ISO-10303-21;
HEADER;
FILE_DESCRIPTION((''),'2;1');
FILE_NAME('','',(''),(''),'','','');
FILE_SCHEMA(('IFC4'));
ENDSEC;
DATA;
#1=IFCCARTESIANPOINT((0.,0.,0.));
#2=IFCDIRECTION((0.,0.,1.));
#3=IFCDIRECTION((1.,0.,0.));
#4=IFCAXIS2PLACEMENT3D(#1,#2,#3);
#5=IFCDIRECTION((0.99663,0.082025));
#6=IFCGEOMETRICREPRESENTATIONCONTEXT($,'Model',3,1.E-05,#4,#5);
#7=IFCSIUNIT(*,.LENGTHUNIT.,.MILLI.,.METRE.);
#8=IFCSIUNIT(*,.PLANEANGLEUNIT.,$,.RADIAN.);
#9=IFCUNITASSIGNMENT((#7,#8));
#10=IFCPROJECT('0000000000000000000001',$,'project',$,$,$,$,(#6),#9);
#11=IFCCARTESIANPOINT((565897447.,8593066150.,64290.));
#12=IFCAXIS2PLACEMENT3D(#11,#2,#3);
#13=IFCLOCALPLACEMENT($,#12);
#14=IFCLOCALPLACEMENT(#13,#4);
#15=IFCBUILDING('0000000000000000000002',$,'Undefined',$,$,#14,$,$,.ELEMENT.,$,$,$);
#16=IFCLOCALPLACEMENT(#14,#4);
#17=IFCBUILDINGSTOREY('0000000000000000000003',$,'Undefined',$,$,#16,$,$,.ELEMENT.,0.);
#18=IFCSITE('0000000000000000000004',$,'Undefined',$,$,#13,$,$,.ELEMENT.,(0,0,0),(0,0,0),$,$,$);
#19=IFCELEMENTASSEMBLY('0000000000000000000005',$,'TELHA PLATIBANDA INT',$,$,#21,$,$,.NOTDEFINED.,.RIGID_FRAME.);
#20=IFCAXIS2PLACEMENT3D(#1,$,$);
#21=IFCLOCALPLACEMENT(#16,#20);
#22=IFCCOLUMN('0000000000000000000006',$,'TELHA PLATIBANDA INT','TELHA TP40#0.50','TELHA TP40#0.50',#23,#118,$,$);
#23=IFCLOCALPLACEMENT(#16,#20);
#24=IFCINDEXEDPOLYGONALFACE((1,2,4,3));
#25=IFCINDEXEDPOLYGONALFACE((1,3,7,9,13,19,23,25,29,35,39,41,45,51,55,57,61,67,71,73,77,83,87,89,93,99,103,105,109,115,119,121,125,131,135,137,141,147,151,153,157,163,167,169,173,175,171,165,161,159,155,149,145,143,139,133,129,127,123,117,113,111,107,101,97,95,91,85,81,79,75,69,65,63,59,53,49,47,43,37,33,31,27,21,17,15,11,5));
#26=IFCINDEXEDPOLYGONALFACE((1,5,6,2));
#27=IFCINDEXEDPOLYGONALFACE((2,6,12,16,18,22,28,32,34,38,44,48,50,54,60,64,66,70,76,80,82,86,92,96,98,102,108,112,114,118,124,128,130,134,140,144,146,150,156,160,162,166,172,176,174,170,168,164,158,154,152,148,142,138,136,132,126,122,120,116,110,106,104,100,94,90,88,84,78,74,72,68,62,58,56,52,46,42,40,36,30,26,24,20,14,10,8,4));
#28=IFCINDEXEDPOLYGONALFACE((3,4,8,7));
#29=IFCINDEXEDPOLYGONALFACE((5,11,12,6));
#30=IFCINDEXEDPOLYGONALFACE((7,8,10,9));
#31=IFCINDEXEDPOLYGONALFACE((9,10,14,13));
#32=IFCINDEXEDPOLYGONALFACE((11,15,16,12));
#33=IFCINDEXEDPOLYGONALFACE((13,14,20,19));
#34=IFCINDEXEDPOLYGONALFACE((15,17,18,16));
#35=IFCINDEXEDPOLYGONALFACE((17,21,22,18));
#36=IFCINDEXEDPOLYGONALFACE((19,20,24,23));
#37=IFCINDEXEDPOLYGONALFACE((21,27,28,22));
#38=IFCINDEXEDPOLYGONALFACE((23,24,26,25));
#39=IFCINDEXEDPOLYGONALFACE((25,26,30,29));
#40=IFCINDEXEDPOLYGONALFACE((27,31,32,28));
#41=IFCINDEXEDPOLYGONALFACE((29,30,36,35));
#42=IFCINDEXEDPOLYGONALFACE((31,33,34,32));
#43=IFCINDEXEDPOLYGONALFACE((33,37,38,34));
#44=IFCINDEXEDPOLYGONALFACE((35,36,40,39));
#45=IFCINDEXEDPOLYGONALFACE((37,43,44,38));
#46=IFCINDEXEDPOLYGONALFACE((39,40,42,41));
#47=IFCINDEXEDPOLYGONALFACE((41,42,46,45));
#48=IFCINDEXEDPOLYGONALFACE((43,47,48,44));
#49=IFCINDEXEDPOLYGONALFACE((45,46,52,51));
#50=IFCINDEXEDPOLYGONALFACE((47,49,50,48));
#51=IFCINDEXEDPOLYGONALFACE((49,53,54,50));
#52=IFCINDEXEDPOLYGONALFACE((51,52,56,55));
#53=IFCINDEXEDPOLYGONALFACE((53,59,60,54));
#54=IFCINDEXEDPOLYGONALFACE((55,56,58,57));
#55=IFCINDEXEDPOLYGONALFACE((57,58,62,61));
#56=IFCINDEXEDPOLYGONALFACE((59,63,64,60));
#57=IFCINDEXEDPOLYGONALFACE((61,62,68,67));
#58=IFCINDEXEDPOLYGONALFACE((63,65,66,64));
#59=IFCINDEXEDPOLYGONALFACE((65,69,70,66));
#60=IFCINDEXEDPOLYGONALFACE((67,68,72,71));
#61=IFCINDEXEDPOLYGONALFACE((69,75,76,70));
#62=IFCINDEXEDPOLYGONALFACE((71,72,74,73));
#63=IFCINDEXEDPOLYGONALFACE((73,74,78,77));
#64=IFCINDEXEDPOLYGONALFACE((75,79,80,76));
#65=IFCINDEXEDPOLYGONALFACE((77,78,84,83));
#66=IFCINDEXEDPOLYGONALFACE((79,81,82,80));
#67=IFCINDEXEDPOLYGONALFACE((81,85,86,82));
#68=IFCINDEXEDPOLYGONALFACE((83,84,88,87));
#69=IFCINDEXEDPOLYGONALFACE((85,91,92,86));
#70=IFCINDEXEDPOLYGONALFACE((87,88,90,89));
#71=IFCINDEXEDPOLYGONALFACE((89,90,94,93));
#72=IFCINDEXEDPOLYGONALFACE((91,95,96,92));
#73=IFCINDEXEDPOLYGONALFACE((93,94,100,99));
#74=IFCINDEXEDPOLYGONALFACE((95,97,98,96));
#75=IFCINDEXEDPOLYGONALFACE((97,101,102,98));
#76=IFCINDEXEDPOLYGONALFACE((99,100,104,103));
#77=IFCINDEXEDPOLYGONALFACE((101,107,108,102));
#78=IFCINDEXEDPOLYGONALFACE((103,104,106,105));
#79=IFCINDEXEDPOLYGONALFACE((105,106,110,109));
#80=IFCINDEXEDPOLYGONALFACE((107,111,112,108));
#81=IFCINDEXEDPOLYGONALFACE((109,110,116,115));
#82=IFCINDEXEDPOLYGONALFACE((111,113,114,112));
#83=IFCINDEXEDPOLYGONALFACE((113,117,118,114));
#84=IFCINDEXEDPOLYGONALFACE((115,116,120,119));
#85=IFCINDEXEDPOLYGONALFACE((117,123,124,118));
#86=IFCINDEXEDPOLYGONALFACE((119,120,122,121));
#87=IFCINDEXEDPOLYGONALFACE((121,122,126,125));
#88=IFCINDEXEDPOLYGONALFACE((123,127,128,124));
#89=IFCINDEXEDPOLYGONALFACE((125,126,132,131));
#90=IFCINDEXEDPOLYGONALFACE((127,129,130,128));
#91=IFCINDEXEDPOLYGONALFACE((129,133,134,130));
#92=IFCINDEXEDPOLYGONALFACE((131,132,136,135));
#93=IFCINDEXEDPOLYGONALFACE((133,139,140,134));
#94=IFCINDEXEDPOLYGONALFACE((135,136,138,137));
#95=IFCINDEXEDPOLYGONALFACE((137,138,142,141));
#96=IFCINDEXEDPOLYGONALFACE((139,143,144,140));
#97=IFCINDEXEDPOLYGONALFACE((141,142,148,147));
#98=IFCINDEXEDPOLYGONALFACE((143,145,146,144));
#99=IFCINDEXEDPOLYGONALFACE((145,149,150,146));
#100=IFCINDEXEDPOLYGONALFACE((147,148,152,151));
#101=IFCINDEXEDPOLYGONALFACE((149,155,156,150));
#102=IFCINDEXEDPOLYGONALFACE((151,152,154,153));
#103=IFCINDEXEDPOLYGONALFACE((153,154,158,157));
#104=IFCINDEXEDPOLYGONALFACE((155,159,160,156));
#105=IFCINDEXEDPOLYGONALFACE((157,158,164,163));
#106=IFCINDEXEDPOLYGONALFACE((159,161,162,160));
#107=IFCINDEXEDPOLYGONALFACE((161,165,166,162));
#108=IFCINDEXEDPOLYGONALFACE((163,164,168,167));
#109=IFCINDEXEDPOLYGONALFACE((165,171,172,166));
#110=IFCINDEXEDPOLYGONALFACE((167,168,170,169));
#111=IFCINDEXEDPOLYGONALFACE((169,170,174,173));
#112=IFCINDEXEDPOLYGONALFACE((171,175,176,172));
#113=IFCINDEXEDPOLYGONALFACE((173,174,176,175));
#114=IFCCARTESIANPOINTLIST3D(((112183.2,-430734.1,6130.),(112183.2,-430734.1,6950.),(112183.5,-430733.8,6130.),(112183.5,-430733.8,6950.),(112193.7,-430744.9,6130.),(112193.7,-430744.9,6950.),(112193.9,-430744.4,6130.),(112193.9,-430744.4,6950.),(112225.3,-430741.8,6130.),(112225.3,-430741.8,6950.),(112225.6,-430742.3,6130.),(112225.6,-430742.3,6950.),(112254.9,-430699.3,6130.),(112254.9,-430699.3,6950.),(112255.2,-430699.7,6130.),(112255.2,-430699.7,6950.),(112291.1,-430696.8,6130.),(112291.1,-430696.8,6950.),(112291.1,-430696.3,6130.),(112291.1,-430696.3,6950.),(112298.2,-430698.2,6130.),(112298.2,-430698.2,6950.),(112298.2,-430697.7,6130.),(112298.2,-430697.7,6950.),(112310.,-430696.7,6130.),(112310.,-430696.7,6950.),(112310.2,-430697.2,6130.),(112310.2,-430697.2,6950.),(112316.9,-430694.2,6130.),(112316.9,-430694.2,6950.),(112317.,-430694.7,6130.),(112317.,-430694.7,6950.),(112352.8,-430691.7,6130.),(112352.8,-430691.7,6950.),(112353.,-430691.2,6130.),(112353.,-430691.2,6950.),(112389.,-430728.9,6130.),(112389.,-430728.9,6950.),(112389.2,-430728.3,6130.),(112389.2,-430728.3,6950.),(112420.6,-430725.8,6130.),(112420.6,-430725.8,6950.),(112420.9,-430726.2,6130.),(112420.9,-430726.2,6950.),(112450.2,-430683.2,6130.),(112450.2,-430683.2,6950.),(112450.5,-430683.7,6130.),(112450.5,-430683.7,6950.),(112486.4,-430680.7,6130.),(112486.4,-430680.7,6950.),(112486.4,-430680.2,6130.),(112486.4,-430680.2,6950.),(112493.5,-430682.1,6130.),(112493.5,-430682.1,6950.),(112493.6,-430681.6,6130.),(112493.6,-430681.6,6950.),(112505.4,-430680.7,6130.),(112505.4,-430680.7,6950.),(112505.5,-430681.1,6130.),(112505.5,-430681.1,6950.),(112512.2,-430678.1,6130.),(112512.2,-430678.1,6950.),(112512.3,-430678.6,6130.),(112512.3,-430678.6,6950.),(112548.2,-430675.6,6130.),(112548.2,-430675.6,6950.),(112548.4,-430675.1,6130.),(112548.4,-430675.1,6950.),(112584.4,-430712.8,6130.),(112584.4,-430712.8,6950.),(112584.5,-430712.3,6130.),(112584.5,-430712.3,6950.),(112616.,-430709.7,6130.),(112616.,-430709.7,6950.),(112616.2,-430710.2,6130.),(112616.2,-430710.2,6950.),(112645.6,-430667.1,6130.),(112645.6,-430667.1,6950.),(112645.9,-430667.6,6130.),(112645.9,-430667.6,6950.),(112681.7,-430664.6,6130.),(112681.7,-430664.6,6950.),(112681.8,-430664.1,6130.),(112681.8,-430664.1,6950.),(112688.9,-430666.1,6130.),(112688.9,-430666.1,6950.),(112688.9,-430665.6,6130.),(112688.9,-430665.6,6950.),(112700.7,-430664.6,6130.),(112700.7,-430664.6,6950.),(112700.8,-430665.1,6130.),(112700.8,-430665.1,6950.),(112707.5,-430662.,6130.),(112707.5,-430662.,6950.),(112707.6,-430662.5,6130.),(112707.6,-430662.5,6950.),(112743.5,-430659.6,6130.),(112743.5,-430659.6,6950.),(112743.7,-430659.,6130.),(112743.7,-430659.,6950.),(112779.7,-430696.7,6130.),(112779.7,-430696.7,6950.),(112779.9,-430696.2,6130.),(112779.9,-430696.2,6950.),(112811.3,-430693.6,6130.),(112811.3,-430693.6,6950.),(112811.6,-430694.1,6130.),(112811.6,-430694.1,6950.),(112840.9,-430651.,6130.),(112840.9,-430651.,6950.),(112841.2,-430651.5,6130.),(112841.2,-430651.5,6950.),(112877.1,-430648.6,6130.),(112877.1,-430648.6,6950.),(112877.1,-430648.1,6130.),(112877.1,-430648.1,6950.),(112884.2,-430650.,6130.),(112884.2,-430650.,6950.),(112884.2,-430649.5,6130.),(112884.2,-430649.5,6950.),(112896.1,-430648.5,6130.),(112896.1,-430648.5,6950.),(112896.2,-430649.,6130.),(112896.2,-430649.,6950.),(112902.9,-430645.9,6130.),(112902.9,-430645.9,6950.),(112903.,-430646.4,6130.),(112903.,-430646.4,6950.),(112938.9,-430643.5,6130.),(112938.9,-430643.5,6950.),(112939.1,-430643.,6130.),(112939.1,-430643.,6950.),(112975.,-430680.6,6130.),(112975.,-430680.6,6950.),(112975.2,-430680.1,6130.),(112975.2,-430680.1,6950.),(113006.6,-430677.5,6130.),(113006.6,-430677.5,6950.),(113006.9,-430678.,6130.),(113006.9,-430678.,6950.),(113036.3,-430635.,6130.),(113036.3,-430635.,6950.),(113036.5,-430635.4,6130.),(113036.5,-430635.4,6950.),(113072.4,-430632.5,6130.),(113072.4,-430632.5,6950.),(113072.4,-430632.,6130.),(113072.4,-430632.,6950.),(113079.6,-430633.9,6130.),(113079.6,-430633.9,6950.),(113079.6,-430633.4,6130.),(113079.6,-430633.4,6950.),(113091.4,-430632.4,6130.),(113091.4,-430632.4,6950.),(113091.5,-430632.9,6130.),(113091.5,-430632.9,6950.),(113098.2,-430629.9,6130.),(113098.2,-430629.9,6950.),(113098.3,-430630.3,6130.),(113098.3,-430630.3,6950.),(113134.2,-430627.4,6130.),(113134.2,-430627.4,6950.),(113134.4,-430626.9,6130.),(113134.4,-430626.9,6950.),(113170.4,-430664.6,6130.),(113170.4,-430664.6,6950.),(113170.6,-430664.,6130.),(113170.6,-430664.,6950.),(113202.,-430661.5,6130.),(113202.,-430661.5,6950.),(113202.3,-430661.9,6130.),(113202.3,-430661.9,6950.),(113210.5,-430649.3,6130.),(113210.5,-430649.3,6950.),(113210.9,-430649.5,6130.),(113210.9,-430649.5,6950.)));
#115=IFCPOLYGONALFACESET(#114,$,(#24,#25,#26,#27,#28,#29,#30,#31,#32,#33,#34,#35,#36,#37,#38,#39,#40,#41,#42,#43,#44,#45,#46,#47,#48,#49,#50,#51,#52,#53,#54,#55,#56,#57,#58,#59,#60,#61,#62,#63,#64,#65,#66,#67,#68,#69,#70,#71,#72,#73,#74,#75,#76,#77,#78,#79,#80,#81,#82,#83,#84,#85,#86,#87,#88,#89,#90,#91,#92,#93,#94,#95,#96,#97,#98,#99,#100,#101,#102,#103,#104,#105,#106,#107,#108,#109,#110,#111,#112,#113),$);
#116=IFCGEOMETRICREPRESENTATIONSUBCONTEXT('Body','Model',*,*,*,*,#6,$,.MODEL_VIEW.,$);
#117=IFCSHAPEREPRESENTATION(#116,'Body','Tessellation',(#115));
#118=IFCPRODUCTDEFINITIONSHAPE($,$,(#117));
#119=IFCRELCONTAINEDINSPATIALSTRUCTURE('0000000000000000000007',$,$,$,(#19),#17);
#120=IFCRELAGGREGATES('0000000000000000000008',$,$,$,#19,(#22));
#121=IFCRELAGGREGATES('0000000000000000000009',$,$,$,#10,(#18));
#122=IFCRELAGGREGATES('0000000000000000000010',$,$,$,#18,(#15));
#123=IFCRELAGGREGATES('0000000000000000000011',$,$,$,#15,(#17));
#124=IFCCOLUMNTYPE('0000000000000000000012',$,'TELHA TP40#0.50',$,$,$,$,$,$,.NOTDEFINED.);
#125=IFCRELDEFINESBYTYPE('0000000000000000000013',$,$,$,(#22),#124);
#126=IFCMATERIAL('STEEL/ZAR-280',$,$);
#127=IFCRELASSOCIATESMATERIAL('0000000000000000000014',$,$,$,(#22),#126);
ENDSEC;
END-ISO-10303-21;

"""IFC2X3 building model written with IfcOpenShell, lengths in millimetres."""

from ifc_helpers import new_model, si_unit, direction, frame, origin_with_axes, place, context, subcontext, project, spatial, polyline, outline, extrude, material, type_object, element, aggregate, save


model = new_model("IFC2X3")

# Units and contexts
model_context = context("Model", 3, precision=1e-05, world=origin_with_axes(), true_north=direction((0.99663, 0.082025)))
body_context = subcontext(model_context, "Body", "Model", "MODEL_VIEW")
ifc_project = project(units=[si_unit("LENGTHUNIT", "METRE", prefix="MILLI"), si_unit("PLANEANGLEUNIT", "RADIAN")], contexts=[model_context])

# Site, building, storey
site_placement = place(None, frame((565897447.0, 8593066150.0, 64290.0), z_axis=(0.0, 0.0, 1.0), x_axis=(1.0, 0.0, 0.0)))
site = spatial("IfcSite", under=ifc_project, at=site_placement, Name="Undefined", CompositionType="ELEMENT", RefLatitude=(0, 0, 0), RefLongitude=(0, 0, 0))
building_placement = place(site_placement, origin_with_axes())
building = spatial("IfcBuilding", under=site, at=building_placement, Name="Undefined", CompositionType="ELEMENT")
storey_placement = place(building_placement, origin_with_axes())
storey = spatial("IfcBuildingStorey", under=building, at=storey_placement, Name="Undefined", CompositionType="ELEMENT", Elevation=0.0)

# Element assembly, column
assembly_1_placement = place(storey_placement, origin_with_axes())
assembly_1 = element("IfcElementAssembly", 1, at=assembly_1_placement, inside=storey, Name="TELHA PLATIBANDA INT", AssemblyPlace="NOTDEFINED", PredefinedType="RIGID_FRAME")
ifc_material_1 = material(Name="STEEL/ZAR-280")
column_type = type_object("IfcColumnType", Name="TELHA TP40#0.50", PredefinedType="NOTDEFINED")
column_1_placement = place(assembly_1_placement, frame((112696.5, -430683.2, 6130.0), z_axis=(0.0, 0.0, 1.0), x_axis=(0.082025, -0.99663, 0.0)))
column_1 = element("IfcColumn", 2, at=column_1_placement, type_object=column_type, material=ifc_material_1, Name="TELHA PLATIBANDA INT", Description="TELHA TP40#0.50", ObjectType="TELHA TP40#0.50", context=body_context, shape_type="SweptSolid", body=[
    extrude(outline(polyline([(440.8, -19.8), (473.8, 20.2), (505.8, 20.2), (515.4, 8.6), (515.0, 8.3), (505.6, 19.8), (474.0, 19.8), (441.0, -20.2), (404.7, -20.2), (397.7, -18.2), (385.9, -18.2), (378.9, -20.2), (342.6, -20.2), (309.6, 19.8), (278.0, 19.8), (245.0, -20.2), (208.7, -20.2), (201.7, -18.2), (189.9, -18.2), (182.9, -20.2), (146.6, -20.2), (113.6, 19.8), (82.0, 19.8), (49.0, -20.2), (12.7, -20.2), (5.7, -18.2), (-6.1, -18.2), (-13.1, -20.2), (-49.4, -20.2), (-82.4, 19.8), (-114.0, 19.8), (-147.0, -20.2), (-183.3, -20.2), (-190.3, -18.2), (-202.1, -18.2), (-209.1, -20.2), (-245.4, -20.2), (-278.4, 19.8), (-310.0, 19.8), (-343.0, -20.2), (-379.3, -20.2), (-386.3, -18.2), (-398.1, -18.2), (-405.1, -20.2), (-441.4, -20.2), (-474.4, 19.8), (-506.0, 19.8), (-515.4, 8.3), (-515.8, 8.6), (-506.2, 20.2), (-474.2, 20.2), (-441.2, -19.8), (-405.2, -19.8), (-398.2, -17.8), (-386.2, -17.8), (-379.2, -19.8), (-343.2, -19.8), (-310.2, 20.2), (-278.2, 20.2), (-245.2, -19.8), (-209.2, -19.8), (-202.2, -17.8), (-190.2, -17.8), (-183.2, -19.8), (-147.2, -19.8), (-114.2, 20.2), (-82.2, 20.2), (-49.2, -19.8), (-13.2, -19.8), (-6.2, -17.8), (5.8, -17.8), (12.8, -19.8), (48.8, -19.8), (81.8, 20.2), (113.8, 20.2), (146.8, -19.8), (182.8, -19.8), (189.8, -17.8), (201.8, -17.8), (208.8, -19.8), (244.8, -19.8), (277.8, 20.2), (309.8, 20.2), (342.8, -19.8), (378.8, -19.8), (385.8, -17.8), (397.8, -17.8), (404.8, -19.8), (440.8, -19.8)])), frame((0.0, 0.0, 820.0), z_axis=(0.0, 0.0, -1.0), x_axis=(0.0, 1.0, 0.0)), (0.0, 0.0, 1.0), 820.0),
])
aggregate(assembly_1, [column_1])

save(model, "model.ifc")
